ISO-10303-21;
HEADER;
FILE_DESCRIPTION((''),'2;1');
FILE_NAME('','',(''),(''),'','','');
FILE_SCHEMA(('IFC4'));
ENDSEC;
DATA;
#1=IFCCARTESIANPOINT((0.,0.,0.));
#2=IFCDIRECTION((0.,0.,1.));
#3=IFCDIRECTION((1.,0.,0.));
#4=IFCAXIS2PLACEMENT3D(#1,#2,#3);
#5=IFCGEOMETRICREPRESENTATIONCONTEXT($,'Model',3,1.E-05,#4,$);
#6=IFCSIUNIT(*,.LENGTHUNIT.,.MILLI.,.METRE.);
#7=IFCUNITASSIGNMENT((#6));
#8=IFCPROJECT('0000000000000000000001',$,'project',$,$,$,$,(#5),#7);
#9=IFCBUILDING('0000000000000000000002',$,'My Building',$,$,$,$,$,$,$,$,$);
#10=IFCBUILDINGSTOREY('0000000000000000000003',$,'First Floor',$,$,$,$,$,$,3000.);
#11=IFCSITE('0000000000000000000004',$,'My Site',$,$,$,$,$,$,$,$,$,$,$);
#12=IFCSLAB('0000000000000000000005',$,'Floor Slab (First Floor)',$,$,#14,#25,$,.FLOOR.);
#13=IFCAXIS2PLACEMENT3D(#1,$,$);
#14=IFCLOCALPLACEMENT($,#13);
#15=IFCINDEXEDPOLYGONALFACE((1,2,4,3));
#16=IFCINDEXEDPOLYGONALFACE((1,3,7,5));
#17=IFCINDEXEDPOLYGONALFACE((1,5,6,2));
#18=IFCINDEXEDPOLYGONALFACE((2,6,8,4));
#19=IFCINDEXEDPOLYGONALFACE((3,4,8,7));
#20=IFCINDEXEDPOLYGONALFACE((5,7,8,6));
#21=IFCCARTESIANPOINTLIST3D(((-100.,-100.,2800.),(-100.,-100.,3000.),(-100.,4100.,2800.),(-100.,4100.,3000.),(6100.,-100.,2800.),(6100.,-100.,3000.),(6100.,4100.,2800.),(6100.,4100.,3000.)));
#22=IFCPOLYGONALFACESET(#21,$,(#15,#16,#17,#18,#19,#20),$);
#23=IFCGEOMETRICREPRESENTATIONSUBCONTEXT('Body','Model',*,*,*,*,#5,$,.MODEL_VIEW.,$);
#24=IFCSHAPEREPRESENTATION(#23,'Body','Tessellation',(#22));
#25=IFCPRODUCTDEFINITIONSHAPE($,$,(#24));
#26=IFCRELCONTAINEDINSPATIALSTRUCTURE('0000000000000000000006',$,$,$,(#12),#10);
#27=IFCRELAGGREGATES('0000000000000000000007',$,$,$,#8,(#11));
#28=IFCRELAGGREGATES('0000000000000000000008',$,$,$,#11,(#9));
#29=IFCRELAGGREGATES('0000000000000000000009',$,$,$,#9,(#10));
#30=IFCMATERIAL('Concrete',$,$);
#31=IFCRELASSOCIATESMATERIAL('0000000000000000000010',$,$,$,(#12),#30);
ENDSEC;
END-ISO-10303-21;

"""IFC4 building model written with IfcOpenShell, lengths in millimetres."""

from ifc_helpers import new_model, si_unit, frame, origin_with_axes, place, context, subcontext, project, spatial, indexed_curve, outline, extrude, material, element, save


model = new_model("IFC4")

# Units and contexts
model_context = context("Model", 3, precision=1e-05, world=origin_with_axes())
body_context = subcontext(model_context, "Body", "Model", "MODEL_VIEW")
ifc_project = project(units=[si_unit("LENGTHUNIT", "METRE", prefix="MILLI")], contexts=[model_context])

# Site, building, storey
site = spatial("IfcSite", under=ifc_project, Name="My Site")
building = spatial("IfcBuilding", under=site, Name="My Building")
storey = spatial("IfcBuildingStorey", under=building, Name="First Floor", Elevation=3000.0)

# Slab
ifc_material = material(Name="Concrete")
slab_placement = place(None, frame((0.0, 0.0, 2800.0), z_axis=(0.0, 0.0, 1.0), x_axis=(1.0, 0.0, 0.0)))
element("IfcSlab", 1, at=slab_placement, inside=storey, material=ifc_material, Name="Floor Slab (First Floor)", PredefinedType="FLOOR", context=body_context, shape_type="SweptSolid", body=[
    extrude(outline(indexed_curve([(-100.0, -100.0), (6100.0, -100.0), (6100.0, 4100.0), (-100.0, 4100.0)])), None, (0.0, 0.0, 1.0), 200.0),
])

save(model, "model.ifc")
